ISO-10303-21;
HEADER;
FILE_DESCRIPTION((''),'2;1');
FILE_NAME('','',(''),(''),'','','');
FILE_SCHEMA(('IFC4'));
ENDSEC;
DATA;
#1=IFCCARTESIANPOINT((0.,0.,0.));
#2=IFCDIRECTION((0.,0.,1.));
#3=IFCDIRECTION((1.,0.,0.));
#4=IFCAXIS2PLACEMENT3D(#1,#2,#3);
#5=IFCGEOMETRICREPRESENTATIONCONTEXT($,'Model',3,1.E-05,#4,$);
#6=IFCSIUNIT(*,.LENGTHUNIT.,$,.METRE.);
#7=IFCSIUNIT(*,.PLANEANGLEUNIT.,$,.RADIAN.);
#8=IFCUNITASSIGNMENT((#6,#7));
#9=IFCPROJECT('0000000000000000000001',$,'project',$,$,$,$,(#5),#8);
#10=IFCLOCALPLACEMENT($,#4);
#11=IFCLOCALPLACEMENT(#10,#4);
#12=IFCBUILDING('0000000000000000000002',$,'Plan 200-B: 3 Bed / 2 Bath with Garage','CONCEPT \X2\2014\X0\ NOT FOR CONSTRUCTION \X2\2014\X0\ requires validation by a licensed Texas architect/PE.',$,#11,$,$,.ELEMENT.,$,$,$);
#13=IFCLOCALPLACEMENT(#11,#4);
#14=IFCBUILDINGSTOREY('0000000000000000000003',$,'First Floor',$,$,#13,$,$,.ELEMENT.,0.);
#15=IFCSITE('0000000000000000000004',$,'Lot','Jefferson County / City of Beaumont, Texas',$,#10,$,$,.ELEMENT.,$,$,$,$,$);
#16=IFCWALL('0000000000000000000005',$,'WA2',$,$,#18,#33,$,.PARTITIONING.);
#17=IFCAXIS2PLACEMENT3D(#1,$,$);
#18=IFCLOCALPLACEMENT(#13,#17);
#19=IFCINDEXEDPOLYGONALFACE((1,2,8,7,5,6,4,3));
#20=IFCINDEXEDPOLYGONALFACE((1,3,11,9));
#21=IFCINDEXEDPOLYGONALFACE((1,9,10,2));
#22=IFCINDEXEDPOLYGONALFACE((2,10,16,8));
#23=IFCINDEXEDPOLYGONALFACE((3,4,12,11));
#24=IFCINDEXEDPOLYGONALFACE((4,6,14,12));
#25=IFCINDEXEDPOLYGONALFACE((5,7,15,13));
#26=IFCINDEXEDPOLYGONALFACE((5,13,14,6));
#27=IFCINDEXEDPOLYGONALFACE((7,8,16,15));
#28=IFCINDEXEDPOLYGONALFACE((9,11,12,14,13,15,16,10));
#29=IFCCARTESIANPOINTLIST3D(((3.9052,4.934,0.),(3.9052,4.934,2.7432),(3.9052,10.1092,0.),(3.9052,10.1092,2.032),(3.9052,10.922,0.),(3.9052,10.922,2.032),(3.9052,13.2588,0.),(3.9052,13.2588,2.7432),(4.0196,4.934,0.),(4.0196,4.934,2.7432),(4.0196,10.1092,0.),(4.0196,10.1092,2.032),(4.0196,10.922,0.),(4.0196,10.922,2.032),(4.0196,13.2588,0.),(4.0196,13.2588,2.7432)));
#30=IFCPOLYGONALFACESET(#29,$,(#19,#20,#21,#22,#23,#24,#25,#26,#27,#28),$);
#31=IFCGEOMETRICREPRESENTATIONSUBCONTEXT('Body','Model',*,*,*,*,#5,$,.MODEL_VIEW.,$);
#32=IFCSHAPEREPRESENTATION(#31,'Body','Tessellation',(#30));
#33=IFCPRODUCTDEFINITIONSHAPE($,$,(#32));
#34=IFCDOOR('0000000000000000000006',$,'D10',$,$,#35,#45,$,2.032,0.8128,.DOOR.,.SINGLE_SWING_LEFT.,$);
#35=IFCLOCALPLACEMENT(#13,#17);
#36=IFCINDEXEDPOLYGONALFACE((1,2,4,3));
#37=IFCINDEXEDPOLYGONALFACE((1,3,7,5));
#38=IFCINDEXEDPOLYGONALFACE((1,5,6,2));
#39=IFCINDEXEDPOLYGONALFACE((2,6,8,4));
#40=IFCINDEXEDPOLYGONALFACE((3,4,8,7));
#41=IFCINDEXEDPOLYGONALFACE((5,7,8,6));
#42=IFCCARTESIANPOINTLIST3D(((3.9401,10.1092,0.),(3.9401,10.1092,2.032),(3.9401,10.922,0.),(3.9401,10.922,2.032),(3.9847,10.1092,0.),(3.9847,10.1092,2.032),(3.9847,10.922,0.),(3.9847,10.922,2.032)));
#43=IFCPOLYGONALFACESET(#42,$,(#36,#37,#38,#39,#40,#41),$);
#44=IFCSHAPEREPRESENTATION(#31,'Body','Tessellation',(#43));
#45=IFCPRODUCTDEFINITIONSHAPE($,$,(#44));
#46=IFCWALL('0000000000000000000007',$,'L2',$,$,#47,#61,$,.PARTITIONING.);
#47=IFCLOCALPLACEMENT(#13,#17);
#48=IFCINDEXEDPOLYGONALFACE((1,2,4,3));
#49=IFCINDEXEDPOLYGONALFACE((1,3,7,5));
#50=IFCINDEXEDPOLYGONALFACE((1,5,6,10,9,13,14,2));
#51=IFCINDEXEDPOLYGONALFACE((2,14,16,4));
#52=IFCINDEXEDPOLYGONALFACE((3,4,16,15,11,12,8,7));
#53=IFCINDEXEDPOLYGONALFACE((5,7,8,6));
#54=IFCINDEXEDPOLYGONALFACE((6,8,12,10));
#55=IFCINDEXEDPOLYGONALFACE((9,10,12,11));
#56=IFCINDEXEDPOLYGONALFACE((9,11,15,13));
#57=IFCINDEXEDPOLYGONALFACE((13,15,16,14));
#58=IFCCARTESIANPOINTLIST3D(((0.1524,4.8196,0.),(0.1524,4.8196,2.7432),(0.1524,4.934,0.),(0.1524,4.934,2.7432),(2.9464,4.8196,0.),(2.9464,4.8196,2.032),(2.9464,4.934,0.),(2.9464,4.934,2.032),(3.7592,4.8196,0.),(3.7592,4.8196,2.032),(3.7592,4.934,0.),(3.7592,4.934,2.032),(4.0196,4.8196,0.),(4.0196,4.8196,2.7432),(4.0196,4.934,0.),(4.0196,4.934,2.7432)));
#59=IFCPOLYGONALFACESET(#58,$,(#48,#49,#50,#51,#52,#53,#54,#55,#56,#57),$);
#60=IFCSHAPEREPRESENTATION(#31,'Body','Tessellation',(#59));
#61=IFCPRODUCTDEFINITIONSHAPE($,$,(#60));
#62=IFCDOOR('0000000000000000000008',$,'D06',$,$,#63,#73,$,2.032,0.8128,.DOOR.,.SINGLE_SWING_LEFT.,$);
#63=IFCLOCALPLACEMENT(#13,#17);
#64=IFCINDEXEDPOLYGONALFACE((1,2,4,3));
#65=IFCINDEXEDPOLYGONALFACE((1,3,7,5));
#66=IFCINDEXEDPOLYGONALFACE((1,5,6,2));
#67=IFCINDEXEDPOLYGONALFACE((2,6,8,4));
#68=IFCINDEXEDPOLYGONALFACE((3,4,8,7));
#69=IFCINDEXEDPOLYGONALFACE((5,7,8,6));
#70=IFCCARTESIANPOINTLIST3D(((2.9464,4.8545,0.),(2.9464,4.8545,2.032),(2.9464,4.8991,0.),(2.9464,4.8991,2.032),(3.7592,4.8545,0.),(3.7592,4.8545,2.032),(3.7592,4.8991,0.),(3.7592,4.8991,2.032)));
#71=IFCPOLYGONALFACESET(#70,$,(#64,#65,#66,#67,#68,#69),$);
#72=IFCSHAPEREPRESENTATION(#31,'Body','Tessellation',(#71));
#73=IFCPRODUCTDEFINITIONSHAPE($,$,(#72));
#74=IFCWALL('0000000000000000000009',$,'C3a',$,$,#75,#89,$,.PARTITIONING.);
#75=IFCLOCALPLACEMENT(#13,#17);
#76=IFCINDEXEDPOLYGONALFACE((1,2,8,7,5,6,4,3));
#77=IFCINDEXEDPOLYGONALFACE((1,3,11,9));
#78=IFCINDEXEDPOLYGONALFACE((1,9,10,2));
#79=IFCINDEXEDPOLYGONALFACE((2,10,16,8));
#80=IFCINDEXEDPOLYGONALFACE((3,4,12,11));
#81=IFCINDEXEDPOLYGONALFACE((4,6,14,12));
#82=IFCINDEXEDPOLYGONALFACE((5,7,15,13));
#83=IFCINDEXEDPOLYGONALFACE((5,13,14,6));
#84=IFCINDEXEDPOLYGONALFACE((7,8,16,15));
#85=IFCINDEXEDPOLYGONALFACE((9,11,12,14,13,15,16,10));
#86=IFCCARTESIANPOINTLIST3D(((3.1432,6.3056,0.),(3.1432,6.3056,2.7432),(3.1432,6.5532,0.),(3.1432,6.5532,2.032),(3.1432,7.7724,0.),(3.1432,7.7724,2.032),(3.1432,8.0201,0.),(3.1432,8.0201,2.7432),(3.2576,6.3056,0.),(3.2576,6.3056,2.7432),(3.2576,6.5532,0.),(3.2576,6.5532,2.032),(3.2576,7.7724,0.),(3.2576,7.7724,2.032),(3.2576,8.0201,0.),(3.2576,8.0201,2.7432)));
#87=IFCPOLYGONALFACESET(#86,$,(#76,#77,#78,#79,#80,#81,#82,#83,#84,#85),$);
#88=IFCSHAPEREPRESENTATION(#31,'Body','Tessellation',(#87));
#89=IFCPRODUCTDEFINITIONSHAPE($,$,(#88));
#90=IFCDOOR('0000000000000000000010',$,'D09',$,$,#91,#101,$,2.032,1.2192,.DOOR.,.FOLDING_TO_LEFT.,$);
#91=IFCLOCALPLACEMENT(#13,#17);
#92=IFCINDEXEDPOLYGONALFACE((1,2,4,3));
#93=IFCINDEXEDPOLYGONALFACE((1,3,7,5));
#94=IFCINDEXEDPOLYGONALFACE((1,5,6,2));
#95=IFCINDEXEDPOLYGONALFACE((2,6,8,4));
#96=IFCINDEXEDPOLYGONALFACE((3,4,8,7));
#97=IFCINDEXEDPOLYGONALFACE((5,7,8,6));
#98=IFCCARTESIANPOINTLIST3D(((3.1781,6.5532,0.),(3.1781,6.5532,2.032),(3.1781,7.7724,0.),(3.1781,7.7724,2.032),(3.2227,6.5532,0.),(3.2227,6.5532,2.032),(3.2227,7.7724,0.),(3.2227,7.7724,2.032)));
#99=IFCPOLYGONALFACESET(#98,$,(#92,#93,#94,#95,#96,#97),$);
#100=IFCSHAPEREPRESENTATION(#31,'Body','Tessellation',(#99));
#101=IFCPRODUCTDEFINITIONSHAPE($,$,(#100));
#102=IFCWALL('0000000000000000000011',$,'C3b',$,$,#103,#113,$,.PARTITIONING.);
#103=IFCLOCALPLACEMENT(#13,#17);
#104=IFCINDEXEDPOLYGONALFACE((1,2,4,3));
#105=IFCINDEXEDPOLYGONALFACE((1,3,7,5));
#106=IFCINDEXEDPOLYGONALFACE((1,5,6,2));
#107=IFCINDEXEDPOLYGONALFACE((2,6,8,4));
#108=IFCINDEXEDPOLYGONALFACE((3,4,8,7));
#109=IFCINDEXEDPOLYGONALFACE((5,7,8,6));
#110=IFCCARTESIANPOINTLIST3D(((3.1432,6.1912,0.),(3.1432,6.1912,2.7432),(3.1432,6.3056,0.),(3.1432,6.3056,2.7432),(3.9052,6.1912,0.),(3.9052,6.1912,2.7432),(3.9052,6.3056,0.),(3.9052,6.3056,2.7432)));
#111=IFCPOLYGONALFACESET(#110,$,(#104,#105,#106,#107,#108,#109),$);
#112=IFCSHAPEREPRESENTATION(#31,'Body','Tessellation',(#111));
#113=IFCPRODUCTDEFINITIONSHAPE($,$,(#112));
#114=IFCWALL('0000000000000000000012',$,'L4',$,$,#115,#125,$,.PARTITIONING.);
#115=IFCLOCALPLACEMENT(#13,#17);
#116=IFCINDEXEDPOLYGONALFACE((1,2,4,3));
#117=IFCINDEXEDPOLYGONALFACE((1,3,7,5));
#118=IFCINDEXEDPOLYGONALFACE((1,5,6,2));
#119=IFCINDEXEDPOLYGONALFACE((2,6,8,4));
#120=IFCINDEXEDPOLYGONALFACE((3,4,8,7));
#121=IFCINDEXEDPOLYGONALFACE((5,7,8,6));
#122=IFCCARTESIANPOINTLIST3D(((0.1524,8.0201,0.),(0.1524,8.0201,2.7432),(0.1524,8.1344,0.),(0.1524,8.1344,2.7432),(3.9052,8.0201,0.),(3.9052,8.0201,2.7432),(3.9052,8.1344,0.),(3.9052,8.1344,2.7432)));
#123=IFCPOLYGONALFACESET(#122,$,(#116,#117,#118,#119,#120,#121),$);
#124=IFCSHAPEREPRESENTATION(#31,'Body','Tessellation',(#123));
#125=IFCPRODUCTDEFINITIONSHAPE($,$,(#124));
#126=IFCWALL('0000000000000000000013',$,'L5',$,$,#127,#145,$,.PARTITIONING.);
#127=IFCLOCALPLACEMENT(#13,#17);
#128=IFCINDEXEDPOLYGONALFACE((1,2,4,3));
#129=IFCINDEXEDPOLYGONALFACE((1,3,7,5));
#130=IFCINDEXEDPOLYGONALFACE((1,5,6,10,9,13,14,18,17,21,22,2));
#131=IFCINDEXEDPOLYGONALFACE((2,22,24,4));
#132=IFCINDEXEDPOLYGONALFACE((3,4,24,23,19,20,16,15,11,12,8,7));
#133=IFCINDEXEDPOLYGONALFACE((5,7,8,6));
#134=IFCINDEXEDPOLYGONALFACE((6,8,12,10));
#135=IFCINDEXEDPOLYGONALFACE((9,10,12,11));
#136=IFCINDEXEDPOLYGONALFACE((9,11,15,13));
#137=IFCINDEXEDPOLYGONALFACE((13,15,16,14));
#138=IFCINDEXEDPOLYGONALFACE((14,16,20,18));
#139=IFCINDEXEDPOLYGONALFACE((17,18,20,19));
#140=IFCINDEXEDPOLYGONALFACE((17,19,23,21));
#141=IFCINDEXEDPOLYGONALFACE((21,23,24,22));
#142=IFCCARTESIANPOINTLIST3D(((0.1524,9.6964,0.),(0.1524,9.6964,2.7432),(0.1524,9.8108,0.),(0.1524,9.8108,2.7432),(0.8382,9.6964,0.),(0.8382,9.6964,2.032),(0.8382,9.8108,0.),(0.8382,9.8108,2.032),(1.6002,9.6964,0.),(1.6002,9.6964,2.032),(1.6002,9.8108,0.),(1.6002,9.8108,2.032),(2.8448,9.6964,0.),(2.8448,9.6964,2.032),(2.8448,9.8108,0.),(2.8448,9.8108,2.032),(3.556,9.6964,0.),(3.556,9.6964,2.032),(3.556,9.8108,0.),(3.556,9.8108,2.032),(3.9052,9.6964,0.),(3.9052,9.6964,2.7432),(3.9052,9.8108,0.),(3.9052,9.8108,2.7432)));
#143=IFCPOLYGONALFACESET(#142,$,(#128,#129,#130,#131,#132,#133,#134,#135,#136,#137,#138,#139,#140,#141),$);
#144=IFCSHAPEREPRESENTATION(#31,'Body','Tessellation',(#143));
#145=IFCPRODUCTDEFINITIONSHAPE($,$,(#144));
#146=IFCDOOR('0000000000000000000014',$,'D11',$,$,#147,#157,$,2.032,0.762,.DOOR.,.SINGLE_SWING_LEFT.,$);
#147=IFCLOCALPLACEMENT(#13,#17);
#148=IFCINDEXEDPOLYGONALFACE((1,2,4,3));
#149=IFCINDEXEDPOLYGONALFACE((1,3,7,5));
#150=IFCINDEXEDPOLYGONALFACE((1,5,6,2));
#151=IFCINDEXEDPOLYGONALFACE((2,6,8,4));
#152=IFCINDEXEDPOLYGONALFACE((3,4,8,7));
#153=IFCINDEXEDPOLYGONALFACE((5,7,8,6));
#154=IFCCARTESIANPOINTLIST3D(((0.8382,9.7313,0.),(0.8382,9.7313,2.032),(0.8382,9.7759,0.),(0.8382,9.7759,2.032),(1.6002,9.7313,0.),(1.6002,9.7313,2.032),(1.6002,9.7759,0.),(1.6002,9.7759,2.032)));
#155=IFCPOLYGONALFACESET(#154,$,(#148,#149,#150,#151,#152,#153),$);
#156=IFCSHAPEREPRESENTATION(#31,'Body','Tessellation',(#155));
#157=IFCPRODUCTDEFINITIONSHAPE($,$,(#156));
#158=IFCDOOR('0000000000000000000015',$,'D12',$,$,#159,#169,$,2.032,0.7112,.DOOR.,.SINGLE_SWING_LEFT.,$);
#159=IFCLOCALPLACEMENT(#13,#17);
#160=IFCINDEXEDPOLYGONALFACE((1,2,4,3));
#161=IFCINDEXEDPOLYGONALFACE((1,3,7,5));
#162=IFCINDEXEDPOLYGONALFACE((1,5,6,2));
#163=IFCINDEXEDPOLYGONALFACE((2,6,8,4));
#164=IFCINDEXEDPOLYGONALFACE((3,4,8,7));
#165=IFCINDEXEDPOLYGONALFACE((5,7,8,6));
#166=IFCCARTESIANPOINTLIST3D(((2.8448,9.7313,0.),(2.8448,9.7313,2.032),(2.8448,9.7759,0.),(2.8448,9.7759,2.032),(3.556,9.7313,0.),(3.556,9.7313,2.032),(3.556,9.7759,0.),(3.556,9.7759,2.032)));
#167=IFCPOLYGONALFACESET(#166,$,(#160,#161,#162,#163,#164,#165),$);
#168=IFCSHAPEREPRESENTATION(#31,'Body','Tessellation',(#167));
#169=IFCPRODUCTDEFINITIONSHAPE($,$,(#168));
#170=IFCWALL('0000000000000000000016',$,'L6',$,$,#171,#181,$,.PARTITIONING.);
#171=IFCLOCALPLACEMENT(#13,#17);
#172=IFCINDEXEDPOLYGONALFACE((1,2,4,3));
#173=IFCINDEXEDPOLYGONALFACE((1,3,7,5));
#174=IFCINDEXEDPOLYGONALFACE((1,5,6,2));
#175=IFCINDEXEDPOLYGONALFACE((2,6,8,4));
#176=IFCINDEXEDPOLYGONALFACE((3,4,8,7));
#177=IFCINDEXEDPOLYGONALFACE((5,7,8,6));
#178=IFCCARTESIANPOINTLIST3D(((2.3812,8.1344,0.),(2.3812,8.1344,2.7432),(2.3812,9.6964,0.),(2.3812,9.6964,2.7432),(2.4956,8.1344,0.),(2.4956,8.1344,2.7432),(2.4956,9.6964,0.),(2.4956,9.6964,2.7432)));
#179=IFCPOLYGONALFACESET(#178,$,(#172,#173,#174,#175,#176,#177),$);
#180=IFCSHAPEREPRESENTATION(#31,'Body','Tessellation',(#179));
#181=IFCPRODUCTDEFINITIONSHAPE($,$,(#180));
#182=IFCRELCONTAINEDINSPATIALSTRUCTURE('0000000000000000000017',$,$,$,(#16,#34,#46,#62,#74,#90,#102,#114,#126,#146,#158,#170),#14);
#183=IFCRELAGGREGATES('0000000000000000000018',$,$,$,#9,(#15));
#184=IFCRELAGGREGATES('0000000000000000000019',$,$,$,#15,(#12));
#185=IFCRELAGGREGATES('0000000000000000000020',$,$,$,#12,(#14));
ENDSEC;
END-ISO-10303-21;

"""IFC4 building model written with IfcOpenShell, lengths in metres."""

from ifc_helpers import new_model, si_unit, frame, frame_2d, origin_with_axes, place, context, subcontext, project, spatial, rectangle, extrude, element, fill, save


model = new_model("IFC4")

# Units and contexts
model_context = context("Model", 3, precision=1e-05, world=origin_with_axes())
body_context = subcontext(model_context, "Body", "Model", "MODEL_VIEW")
ifc_project = project(units=[si_unit("LENGTHUNIT", "METRE"), si_unit("PLANEANGLEUNIT", "RADIAN")], contexts=[model_context])

# Site, building, storey
site_placement = place(None, origin_with_axes())
site = spatial("IfcSite", under=ifc_project, at=site_placement, Name="Lot", Description="Jefferson County / City of Beaumont, Texas", CompositionType="ELEMENT")
building_placement = place(site_placement, origin_with_axes())
building = spatial("IfcBuilding", under=site, at=building_placement, Name="Plan 200-B: 3 Bed / 2 Bath with Garage", Description="CONCEPT — NOT FOR CONSTRUCTION — requires validation by a licensed Texas architect/PE.", CompositionType="ELEMENT")
storey_placement = place(building_placement, origin_with_axes())
storey = spatial("IfcBuildingStorey", under=building, at=storey_placement, Name="First Floor", CompositionType="ELEMENT", Elevation=0.0)

# Walls, openings, doors
wall_1_placement = place(storey_placement, frame((3.9624, 4.934, 0.0), z_axis=(0.0, 0.0, 1.0), x_axis=(0.0, 1.0, 0.0)))
wall_1 = element("IfcWall", 1, at=wall_1_placement, inside=storey, Name="WA2", PredefinedType="PARTITIONING", context=body_context, shape_type="SweptSolid", body=[
    extrude(rectangle(XDim=8.3248, YDim=0.1143, at=frame_2d((4.1624, 0.0), x_axis=(1.0, 0.0))), origin_with_axes(), (0.0, 0.0, 1.0), 2.7432),
])
opening_1_placement = place(wall_1_placement, frame((5.1752, 0.0, 0.0), z_axis=(0.0, 0.0, 1.0), x_axis=(1.0, 0.0, 0.0)))
opening_1 = element("IfcOpeningElement", 2, at=opening_1_placement, cuts=wall_1, PredefinedType="OPENING", context=body_context, shape_type="SweptSolid", body=[
    extrude(rectangle(XDim=0.8128, YDim=0.1448, at=frame_2d((0.4064, 0.0), x_axis=(1.0, 0.0))), origin_with_axes(), (0.0, 0.0, 1.0), 2.032),
])
door_1_placement = place(opening_1_placement, origin_with_axes())
door_1 = element("IfcDoor", 3, at=door_1_placement, inside=storey, Name="D10", OperationType="SINGLE_SWING_LEFT", OverallHeight=2.032, OverallWidth=0.8128, PredefinedType="DOOR", context=body_context, shape_type="SweptSolid", body=[
    extrude(rectangle(XDim=0.8128, YDim=0.0445, at=frame_2d((0.4064, 0.0), x_axis=(1.0, 0.0))), origin_with_axes(), (0.0, 0.0, 1.0), 2.032),
])
fill(opening_1, door_1)
wall_2_placement = place(storey_placement, frame((0.1524, 4.8768, 0.0), z_axis=(0.0, 0.0, 1.0), x_axis=(1.0, 0.0, 0.0)))
wall_2 = element("IfcWall", 4, at=wall_2_placement, inside=storey, Name="L2", PredefinedType="PARTITIONING", context=body_context, shape_type="SweptSolid", body=[
    extrude(rectangle(XDim=3.8672, YDim=0.1143, at=frame_2d((1.9336, 0.0), x_axis=(1.0, 0.0))), origin_with_axes(), (0.0, 0.0, 1.0), 2.7432),
])
opening_2_placement = place(wall_2_placement, frame((2.794, 0.0, 0.0), z_axis=(0.0, 0.0, 1.0), x_axis=(1.0, 0.0, 0.0)))
opening_2 = element("IfcOpeningElement", 5, at=opening_2_placement, cuts=wall_2, PredefinedType="OPENING", context=body_context, shape_type="SweptSolid", body=[
    extrude(rectangle(XDim=0.8128, YDim=0.1448, at=frame_2d((0.4064, 0.0), x_axis=(1.0, 0.0))), origin_with_axes(), (0.0, 0.0, 1.0), 2.032),
])
door_2_placement = place(opening_2_placement, origin_with_axes())
door_2 = element("IfcDoor", 6, at=door_2_placement, inside=storey, Name="D06", OperationType="SINGLE_SWING_LEFT", OverallHeight=2.032, OverallWidth=0.8128, PredefinedType="DOOR", context=body_context, shape_type="SweptSolid", body=[
    extrude(rectangle(XDim=0.8128, YDim=0.0445, at=frame_2d((0.4064, 0.0), x_axis=(1.0, 0.0))), origin_with_axes(), (0.0, 0.0, 1.0), 2.032),
])
fill(opening_2, door_2)
wall_3_placement = place(storey_placement, frame((3.2004, 6.3056, 0.0), z_axis=(0.0, 0.0, 1.0), x_axis=(0.0, 1.0, 0.0)))
wall_3 = element("IfcWall", 7, at=wall_3_placement, inside=storey, Name="C3a", PredefinedType="PARTITIONING", context=body_context, shape_type="SweptSolid", body=[
    extrude(rectangle(XDim=1.7145, YDim=0.1143, at=frame_2d((0.8573, 0.0), x_axis=(1.0, 0.0))), origin_with_axes(), (0.0, 0.0, 1.0), 2.7432),
])
opening_3_placement = place(wall_3_placement, frame((0.2477, 0.0, 0.0), z_axis=(0.0, 0.0, 1.0), x_axis=(1.0, 0.0, 0.0)))
opening_3 = element("IfcOpeningElement", 8, at=opening_3_placement, cuts=wall_3, PredefinedType="OPENING", context=body_context, shape_type="SweptSolid", body=[
    extrude(rectangle(XDim=1.2192, YDim=0.1448, at=frame_2d((0.6096, 0.0), x_axis=(1.0, 0.0))), origin_with_axes(), (0.0, 0.0, 1.0), 2.032),
])
door_3_placement = place(opening_3_placement, origin_with_axes())
door_3 = element("IfcDoor", 9, at=door_3_placement, inside=storey, Name="D09", OperationType="FOLDING_TO_LEFT", OverallHeight=2.032, OverallWidth=1.2192, PredefinedType="DOOR", context=body_context, shape_type="SweptSolid", body=[
    extrude(rectangle(XDim=1.2192, YDim=0.0445, at=frame_2d((0.6096, 0.0), x_axis=(1.0, 0.0))), origin_with_axes(), (0.0, 0.0, 1.0), 2.032),
])
fill(opening_3, door_3)

# Walls
wall_4_placement = place(storey_placement, frame((3.1433, 6.2484, 0.0), z_axis=(0.0, 0.0, 1.0), x_axis=(1.0, 0.0, 0.0)))
element("IfcWall", 10, at=wall_4_placement, inside=storey, Name="C3b", PredefinedType="PARTITIONING", context=body_context, shape_type="SweptSolid", body=[
    extrude(rectangle(XDim=0.762, YDim=0.1143, at=frame_2d((0.381, 0.0), x_axis=(1.0, 0.0))), origin_with_axes(), (0.0, 0.0, 1.0), 2.7432),
])
wall_5_placement = place(storey_placement, frame((0.1524, 8.0772, 0.0), z_axis=(0.0, 0.0, 1.0), x_axis=(1.0, 0.0, 0.0)))
element("IfcWall", 11, at=wall_5_placement, inside=storey, Name="L4", PredefinedType="PARTITIONING", context=body_context, shape_type="SweptSolid", body=[
    extrude(rectangle(XDim=3.7529, YDim=0.1143, at=frame_2d((1.8764, 0.0), x_axis=(1.0, 0.0))), origin_with_axes(), (0.0, 0.0, 1.0), 2.7432),
])

# Wall, openings, doors
wall_6_placement = place(storey_placement, frame((0.1524, 9.7536, 0.0), z_axis=(0.0, 0.0, 1.0), x_axis=(1.0, 0.0, 0.0)))
wall_6 = element("IfcWall", 12, at=wall_6_placement, inside=storey, Name="L5", PredefinedType="PARTITIONING", context=body_context, shape_type="SweptSolid", body=[
    extrude(rectangle(XDim=3.7529, YDim=0.1143, at=frame_2d((1.8764, 0.0), x_axis=(1.0, 0.0))), origin_with_axes(), (0.0, 0.0, 1.0), 2.7432),
])
opening_4_placement = place(wall_6_placement, frame((0.6858, 0.0, 0.0), z_axis=(0.0, 0.0, 1.0), x_axis=(1.0, 0.0, 0.0)))
opening_4 = element("IfcOpeningElement", 13, at=opening_4_placement, cuts=wall_6, PredefinedType="OPENING", context=body_context, shape_type="SweptSolid", body=[
    extrude(rectangle(XDim=0.762, YDim=0.1448, at=frame_2d((0.381, 0.0), x_axis=(1.0, 0.0))), origin_with_axes(), (0.0, 0.0, 1.0), 2.032),
])
opening_5_placement = place(wall_6_placement, frame((2.6924, 0.0, 0.0), z_axis=(0.0, 0.0, 1.0), x_axis=(1.0, 0.0, 0.0)))
opening_5 = element("IfcOpeningElement", 14, at=opening_5_placement, cuts=wall_6, PredefinedType="OPENING", context=body_context, shape_type="SweptSolid", body=[
    extrude(rectangle(XDim=0.7112, YDim=0.1448, at=frame_2d((0.3556, 0.0), x_axis=(1.0, 0.0))), origin_with_axes(), (0.0, 0.0, 1.0), 2.032),
])
door_4_placement = place(opening_4_placement, origin_with_axes())
door_4 = element("IfcDoor", 15, at=door_4_placement, inside=storey, Name="D11", OperationType="SINGLE_SWING_LEFT", OverallHeight=2.032, OverallWidth=0.762, PredefinedType="DOOR", context=body_context, shape_type="SweptSolid", body=[
    extrude(rectangle(XDim=0.762, YDim=0.0445, at=frame_2d((0.381, 0.0), x_axis=(1.0, 0.0))), origin_with_axes(), (0.0, 0.0, 1.0), 2.032),
])
fill(opening_4, door_4)
door_5_placement = place(opening_5_placement, origin_with_axes())
door_5 = element("IfcDoor", 16, at=door_5_placement, inside=storey, Name="D12", OperationType="SINGLE_SWING_LEFT", OverallHeight=2.032, OverallWidth=0.7112, PredefinedType="DOOR", context=body_context, shape_type="SweptSolid", body=[
    extrude(rectangle(XDim=0.7112, YDim=0.0445, at=frame_2d((0.3556, 0.0), x_axis=(1.0, 0.0))), origin_with_axes(), (0.0, 0.0, 1.0), 2.032),
])
fill(opening_5, door_5)

# Wall
wall_7_placement = place(storey_placement, frame((2.4384, 8.1343, 0.0), z_axis=(0.0, 0.0, 1.0), x_axis=(0.0, 1.0, 0.0)))
element("IfcWall", 17, at=wall_7_placement, inside=storey, Name="L6", PredefinedType="PARTITIONING", context=body_context, shape_type="SweptSolid", body=[
    extrude(rectangle(XDim=1.5621, YDim=0.1143, at=frame_2d((0.7811, 0.0), x_axis=(1.0, 0.0))), origin_with_axes(), (0.0, 0.0, 1.0), 2.7432),
])

save(model, "model.ifc")
